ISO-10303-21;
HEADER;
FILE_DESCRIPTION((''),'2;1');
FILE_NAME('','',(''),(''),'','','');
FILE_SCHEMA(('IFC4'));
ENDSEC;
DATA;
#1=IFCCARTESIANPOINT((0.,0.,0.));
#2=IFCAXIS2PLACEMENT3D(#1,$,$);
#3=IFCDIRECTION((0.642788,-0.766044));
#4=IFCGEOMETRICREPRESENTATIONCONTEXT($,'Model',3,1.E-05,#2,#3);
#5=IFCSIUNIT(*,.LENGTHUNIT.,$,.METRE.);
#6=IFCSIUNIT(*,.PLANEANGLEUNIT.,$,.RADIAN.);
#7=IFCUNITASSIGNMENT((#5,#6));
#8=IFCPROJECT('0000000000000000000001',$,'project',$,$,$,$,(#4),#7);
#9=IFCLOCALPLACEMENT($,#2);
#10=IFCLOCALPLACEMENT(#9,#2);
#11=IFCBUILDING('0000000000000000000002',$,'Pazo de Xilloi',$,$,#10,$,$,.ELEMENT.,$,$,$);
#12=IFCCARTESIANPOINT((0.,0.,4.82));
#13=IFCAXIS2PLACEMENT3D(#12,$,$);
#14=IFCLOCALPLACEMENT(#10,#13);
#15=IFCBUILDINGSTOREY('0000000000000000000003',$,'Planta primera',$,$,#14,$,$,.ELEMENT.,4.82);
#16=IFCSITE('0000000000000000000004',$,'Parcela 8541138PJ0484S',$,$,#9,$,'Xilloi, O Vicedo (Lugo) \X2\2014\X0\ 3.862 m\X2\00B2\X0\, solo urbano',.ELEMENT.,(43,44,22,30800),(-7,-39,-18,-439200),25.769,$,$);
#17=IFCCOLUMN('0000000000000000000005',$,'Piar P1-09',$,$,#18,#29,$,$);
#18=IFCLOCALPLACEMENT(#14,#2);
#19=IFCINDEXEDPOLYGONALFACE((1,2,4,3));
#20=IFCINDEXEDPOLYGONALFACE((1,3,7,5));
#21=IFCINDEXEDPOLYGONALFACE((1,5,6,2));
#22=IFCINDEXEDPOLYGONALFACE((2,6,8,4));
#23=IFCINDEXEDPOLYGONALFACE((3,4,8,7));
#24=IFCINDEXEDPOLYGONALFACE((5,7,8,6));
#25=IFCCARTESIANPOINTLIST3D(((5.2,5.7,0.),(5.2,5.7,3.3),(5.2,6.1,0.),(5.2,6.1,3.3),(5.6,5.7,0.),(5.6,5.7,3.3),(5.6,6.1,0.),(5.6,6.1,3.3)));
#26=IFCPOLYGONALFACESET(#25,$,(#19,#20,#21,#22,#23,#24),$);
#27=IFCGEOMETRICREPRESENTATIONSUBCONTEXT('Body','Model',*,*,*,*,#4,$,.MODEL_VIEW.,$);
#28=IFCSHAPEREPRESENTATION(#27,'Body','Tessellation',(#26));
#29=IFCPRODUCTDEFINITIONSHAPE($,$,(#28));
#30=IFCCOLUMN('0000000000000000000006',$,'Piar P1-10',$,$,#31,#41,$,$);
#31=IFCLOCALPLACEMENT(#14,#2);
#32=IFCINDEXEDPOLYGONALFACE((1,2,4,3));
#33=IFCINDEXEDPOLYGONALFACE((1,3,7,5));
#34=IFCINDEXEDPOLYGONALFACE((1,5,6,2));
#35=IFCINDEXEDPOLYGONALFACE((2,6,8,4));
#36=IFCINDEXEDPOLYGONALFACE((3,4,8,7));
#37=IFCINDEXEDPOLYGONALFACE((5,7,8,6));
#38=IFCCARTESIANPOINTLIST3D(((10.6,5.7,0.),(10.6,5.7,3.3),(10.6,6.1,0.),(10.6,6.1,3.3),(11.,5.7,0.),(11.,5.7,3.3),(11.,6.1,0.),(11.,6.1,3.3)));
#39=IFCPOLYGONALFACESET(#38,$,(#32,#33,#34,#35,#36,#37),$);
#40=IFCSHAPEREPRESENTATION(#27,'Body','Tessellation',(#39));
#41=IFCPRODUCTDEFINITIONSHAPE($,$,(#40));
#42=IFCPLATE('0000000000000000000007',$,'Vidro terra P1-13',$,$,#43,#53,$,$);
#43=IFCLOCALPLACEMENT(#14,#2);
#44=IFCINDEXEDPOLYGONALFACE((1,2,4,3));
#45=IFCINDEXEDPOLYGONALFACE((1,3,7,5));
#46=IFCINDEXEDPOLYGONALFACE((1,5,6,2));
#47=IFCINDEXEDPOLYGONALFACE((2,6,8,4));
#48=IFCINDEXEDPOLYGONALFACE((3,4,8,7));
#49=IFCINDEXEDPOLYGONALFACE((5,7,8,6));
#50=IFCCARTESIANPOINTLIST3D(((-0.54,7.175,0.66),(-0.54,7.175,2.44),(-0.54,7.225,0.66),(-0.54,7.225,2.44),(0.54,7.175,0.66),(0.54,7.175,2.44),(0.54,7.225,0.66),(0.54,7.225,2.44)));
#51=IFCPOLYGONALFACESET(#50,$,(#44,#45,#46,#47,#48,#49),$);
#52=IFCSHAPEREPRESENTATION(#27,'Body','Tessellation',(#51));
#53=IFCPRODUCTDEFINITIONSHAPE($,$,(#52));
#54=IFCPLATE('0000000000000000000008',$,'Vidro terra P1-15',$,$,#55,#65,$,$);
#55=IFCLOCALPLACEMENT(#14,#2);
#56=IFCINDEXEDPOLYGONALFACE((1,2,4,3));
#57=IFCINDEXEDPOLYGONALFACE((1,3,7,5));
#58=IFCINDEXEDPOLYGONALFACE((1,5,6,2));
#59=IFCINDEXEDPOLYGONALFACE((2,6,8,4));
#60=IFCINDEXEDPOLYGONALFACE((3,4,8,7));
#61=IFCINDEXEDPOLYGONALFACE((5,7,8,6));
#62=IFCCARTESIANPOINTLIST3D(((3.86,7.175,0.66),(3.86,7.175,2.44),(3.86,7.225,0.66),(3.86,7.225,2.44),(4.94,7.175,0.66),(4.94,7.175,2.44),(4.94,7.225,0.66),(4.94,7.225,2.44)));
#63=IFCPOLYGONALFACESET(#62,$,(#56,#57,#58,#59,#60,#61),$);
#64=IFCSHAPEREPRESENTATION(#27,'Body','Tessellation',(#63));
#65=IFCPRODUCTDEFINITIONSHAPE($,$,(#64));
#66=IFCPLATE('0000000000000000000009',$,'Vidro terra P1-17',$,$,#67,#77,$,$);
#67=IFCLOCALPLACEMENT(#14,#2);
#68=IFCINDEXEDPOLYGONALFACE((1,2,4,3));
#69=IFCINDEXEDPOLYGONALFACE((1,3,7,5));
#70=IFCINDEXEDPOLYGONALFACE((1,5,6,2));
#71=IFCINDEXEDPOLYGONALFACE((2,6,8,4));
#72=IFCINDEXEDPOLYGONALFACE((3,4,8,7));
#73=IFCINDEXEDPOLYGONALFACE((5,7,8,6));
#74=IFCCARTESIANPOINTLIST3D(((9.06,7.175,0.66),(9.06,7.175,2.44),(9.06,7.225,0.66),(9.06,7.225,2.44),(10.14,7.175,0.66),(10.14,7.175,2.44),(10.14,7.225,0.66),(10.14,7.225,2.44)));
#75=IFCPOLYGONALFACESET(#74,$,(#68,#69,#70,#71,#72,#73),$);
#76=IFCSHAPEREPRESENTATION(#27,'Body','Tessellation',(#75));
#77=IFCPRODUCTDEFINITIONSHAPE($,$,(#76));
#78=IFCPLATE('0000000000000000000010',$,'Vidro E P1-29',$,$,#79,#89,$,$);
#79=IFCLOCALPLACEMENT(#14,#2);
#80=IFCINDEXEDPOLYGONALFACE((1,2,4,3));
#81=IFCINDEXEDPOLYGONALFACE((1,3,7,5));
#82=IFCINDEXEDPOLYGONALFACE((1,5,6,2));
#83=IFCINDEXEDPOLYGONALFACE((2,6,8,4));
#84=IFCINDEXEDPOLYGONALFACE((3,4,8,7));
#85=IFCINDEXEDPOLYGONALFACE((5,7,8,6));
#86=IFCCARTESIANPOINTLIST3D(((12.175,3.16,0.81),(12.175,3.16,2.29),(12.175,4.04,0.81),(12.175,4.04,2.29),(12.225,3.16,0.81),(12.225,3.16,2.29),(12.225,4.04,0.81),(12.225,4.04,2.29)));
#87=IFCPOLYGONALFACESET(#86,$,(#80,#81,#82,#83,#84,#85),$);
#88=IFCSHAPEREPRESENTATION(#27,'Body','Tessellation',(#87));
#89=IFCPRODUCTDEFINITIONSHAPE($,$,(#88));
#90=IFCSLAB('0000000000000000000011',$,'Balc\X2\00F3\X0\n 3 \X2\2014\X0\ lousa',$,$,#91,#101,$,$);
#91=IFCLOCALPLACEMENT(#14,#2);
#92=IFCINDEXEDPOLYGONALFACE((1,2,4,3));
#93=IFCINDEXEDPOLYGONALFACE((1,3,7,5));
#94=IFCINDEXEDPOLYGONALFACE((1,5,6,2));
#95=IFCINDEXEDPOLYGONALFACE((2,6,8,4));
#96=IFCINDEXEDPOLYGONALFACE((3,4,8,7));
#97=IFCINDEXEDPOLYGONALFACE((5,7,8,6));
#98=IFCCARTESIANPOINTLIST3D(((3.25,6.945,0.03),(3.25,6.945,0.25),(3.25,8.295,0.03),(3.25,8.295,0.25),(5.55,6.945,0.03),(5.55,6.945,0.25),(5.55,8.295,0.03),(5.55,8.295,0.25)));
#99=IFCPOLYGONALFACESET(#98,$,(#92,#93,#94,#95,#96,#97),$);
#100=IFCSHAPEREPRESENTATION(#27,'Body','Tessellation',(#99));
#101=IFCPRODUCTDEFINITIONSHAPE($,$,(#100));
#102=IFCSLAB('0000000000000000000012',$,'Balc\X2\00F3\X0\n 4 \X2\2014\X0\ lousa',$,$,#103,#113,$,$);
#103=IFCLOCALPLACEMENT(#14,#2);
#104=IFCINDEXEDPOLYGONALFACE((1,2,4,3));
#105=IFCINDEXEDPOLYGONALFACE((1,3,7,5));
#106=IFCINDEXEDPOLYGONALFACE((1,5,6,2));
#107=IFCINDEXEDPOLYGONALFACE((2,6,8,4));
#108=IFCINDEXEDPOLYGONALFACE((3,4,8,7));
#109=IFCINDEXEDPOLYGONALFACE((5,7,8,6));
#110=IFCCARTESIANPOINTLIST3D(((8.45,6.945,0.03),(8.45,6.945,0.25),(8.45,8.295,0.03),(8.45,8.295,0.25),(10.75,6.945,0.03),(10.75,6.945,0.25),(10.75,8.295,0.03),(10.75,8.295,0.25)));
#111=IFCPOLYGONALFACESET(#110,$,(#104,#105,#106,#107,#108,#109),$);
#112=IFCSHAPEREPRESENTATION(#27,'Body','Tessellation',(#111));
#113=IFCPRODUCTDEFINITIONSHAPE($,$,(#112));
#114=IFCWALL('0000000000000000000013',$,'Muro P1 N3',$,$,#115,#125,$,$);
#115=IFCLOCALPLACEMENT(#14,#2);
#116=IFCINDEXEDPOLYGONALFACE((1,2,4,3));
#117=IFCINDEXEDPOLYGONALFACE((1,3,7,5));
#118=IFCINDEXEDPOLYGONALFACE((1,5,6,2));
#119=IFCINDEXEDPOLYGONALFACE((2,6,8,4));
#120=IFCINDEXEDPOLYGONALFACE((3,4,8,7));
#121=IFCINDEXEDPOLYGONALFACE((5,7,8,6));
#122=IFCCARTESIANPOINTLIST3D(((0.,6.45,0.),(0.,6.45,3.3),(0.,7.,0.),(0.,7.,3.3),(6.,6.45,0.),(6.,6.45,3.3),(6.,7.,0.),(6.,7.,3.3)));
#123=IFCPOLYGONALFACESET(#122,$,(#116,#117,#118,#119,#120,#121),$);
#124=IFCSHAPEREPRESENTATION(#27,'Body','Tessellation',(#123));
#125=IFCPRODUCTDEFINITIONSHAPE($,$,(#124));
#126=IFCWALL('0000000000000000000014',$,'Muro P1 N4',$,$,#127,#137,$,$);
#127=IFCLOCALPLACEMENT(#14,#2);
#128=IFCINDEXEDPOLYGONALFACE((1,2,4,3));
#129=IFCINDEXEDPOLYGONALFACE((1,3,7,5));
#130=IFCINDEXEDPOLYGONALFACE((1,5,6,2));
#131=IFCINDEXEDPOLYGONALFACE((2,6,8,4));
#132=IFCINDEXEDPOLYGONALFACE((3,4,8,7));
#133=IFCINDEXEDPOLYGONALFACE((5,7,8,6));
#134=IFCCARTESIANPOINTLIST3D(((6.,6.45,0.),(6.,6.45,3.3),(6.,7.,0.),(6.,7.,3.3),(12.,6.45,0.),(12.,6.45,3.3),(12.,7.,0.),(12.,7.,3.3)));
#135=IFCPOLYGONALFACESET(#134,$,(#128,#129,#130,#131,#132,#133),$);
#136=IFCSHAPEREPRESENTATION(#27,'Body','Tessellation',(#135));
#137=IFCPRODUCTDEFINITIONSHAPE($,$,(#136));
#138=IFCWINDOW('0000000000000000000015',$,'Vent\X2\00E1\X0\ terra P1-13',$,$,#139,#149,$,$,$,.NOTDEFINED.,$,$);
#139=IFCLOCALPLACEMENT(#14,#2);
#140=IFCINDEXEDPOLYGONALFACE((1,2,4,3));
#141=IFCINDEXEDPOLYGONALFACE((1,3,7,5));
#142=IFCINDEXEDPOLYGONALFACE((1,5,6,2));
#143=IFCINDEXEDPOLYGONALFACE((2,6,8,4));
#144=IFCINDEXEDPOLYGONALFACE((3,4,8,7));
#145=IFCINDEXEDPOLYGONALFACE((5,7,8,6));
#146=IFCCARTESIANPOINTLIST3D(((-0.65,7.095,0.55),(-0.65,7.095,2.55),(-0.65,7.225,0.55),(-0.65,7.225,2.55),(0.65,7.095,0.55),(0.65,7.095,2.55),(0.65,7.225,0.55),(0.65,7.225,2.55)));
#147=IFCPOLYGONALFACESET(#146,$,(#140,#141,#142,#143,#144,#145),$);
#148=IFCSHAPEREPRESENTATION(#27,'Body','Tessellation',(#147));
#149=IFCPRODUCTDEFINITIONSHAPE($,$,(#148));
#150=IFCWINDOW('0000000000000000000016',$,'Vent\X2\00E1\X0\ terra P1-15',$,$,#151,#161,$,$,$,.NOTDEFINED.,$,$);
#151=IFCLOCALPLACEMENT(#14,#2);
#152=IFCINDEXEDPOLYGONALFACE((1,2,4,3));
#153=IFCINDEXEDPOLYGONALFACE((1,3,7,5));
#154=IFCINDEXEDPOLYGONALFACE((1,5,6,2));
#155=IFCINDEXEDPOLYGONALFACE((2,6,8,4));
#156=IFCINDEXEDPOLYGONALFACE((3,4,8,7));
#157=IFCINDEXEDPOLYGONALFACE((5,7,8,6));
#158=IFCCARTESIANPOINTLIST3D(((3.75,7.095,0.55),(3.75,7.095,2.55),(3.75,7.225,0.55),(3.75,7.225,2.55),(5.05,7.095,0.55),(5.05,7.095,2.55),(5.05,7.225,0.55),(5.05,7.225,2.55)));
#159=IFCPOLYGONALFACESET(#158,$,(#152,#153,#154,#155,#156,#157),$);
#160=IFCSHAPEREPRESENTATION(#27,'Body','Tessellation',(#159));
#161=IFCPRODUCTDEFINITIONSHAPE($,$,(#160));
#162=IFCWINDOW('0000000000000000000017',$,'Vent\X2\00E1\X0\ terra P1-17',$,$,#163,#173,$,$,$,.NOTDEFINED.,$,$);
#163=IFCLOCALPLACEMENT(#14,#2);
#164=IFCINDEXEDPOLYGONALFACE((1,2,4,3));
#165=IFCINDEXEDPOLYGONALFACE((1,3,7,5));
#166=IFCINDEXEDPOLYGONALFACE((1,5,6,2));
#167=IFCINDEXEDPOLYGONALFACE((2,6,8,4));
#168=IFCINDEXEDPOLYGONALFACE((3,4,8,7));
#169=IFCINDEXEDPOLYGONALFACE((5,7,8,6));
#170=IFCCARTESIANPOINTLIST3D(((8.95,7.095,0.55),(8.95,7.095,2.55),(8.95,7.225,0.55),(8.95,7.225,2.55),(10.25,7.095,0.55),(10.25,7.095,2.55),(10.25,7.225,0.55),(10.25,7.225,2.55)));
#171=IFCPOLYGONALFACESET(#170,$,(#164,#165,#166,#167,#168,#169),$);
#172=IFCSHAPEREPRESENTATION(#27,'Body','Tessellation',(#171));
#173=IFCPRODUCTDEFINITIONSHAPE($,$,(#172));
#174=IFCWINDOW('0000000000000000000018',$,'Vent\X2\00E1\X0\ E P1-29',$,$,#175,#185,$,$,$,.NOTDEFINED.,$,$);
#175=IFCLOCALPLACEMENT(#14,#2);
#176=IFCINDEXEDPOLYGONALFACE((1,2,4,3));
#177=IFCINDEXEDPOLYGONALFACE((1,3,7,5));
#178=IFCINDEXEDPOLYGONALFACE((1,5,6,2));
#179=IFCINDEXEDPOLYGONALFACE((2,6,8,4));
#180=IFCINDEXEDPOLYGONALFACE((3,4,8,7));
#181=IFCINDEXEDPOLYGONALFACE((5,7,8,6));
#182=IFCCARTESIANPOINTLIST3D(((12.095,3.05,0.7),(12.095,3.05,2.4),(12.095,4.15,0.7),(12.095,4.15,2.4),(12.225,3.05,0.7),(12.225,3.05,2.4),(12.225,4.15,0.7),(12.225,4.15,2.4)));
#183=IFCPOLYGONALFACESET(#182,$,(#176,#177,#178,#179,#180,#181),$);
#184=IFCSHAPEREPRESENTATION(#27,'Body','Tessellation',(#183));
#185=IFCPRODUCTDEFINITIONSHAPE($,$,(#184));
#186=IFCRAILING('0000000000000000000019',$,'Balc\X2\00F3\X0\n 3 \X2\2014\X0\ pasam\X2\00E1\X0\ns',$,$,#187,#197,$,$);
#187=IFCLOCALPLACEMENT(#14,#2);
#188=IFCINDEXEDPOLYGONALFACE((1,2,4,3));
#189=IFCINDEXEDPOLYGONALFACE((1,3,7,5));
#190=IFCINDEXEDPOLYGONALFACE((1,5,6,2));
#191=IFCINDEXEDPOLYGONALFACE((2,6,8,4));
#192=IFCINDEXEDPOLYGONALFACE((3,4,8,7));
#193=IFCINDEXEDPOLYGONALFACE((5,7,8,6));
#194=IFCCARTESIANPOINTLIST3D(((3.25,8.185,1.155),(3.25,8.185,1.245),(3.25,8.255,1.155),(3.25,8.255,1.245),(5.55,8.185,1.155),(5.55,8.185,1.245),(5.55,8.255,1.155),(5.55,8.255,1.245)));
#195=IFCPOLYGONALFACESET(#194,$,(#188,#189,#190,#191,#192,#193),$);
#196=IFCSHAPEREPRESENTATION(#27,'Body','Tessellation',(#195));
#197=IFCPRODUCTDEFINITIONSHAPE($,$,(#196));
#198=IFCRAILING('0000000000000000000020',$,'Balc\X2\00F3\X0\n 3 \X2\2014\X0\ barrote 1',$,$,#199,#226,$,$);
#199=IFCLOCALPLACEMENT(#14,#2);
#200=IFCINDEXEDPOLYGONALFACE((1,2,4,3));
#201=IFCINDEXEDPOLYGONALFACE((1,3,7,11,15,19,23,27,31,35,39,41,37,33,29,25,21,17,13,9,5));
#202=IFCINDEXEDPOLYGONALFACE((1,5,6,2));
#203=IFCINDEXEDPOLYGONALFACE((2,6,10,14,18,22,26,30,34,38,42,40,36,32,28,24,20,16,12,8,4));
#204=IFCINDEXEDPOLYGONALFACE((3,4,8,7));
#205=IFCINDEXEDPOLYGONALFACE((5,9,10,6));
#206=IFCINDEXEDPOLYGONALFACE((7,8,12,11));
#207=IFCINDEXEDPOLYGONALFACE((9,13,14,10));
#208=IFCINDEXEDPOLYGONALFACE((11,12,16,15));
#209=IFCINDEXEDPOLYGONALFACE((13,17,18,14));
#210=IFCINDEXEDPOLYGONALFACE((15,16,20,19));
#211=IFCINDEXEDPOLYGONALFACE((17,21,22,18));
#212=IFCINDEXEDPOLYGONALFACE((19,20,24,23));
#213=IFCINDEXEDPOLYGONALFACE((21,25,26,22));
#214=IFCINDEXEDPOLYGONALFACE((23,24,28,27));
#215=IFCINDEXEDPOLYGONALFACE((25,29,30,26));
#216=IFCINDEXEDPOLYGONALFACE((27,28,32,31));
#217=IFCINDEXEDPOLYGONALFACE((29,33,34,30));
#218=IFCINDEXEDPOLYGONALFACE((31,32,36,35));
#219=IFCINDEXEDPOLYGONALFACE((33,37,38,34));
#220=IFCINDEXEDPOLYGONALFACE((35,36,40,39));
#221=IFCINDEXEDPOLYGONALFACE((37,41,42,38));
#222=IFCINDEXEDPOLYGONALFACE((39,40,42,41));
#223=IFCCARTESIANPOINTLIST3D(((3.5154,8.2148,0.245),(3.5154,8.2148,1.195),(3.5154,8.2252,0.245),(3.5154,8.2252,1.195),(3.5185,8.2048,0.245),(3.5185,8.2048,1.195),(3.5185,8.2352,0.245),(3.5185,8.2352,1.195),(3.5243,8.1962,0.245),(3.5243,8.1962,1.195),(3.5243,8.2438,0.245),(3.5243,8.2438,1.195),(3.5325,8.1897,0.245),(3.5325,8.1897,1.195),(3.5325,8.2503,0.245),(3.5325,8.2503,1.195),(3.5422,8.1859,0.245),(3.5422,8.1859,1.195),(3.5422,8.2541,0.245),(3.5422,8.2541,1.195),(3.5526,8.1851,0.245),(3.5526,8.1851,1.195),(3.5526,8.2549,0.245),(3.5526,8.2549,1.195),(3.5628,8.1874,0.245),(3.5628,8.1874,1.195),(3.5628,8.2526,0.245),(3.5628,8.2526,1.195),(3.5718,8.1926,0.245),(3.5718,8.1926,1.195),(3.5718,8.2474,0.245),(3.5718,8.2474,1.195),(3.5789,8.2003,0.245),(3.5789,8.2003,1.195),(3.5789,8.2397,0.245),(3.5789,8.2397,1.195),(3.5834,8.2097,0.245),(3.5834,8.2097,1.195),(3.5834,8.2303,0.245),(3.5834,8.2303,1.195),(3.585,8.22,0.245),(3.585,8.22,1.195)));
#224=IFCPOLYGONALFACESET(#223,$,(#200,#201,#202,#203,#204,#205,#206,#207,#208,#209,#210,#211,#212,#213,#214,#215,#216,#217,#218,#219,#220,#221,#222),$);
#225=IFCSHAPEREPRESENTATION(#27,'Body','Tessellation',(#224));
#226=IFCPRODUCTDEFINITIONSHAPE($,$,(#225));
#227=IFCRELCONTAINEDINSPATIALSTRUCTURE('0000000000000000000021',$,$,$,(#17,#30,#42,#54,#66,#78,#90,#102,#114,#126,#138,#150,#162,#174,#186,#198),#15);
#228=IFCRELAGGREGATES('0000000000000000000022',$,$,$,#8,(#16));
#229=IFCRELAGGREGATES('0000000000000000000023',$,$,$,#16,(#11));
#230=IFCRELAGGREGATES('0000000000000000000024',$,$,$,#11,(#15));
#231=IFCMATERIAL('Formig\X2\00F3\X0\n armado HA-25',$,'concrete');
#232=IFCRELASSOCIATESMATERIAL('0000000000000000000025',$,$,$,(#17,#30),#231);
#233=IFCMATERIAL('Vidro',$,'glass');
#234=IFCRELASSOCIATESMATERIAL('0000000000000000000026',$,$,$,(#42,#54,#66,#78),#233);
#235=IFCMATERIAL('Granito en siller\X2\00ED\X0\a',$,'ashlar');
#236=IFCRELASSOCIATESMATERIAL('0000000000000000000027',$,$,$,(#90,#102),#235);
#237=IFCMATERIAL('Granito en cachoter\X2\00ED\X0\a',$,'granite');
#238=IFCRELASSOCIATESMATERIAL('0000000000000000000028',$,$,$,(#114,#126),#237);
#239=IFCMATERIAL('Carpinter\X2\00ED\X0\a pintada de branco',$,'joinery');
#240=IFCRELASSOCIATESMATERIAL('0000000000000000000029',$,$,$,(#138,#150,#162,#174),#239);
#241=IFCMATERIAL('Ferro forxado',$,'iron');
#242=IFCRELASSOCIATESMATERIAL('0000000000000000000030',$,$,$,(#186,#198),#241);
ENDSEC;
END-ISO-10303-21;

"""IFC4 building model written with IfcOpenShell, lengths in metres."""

from ifc_helpers import new_model, si_unit, direction, frame, origin, origin_2d, place, context, subcontext, project, spatial, rectangle, circle, extrude, material, element, save


model = new_model("IFC4")

# Units and contexts
model_context = context("Model", 3, precision=1e-05, world=origin(), true_north=direction((0.642788, -0.766044)))
body_context = subcontext(model_context, "Body", "Model", "MODEL_VIEW")
ifc_project = project(units=[si_unit("LENGTHUNIT", "METRE"), si_unit("PLANEANGLEUNIT", "RADIAN")], contexts=[model_context])

# Site, building, storey
site_placement = place(None, origin())
site = spatial("IfcSite", under=ifc_project, at=site_placement, Name="Parcela 8541138PJ0484S", LongName="Xilloi, O Vicedo (Lugo) — 3.862 m², solo urbano", CompositionType="ELEMENT", RefLatitude=(43, 44, 22, 30800), RefLongitude=(-7, -39, -18, -439200), RefElevation=25.769)
building_placement = place(site_placement, origin())
building = spatial("IfcBuilding", under=site, at=building_placement, Name="Pazo de Xilloi", CompositionType="ELEMENT")
storey_placement = place(building_placement, frame((0.0, 0.0, 4.82)))
storey = spatial("IfcBuildingStorey", under=building, at=storey_placement, Name="Planta primera", CompositionType="ELEMENT", Elevation=4.82)

# Columns
ifc_material_1 = material(Name="Formigón armado HA-25", Category="concrete")
for number, where, name in (
    (1, (5.4, 5.9, 1.65), "Piar P1-09"),
    (2, (10.8, 5.9, 1.65), "Piar P1-10"),
):
    element("IfcColumn", number, at=place(storey_placement, frame(where)), inside=storey, material=ifc_material_1, Name=name, context=body_context, shape_type="SweptSolid", body=[
        extrude(rectangle(XDim=0.4, YDim=0.4, at=origin_2d()), frame((0.0, 0.0, -1.65)), (0.0, 0.0, 1.0), 3.3),
    ])

# Plates
ifc_material_2 = material(Name="Vidro", Category="glass")
for number, where, name in (
    (3, (0.0, 7.2, 1.55), "Vidro terra P1-13"),
    (4, (4.4, 7.2, 1.55), "Vidro terra P1-15"),
    (5, (9.6, 7.2, 1.55), "Vidro terra P1-17"),
):
    element("IfcPlate", number, at=place(storey_placement, frame(where)), inside=storey, material=ifc_material_2, Name=name, context=body_context, shape_type="SweptSolid", body=[
        extrude(rectangle(XDim=1.08, YDim=0.05, at=origin_2d()), frame((0.0, 0.0, -0.89)), (0.0, 0.0, 1.0), 1.78),
    ])
plate_placement = place(storey_placement, frame((12.2, 3.6, 1.55)))
element("IfcPlate", 6, at=plate_placement, inside=storey, material=ifc_material_2, Name="Vidro E P1-29", context=body_context, shape_type="SweptSolid", body=[
    extrude(rectangle(XDim=0.05, YDim=0.88, at=origin_2d()), frame((0.0, 0.0, -0.74)), (0.0, 0.0, 1.0), 1.48),
])

# Slabs
ifc_material_3 = material(Name="Granito en sillería", Category="ashlar")
for number, where, name in (
    (7, (4.4, 7.62, 0.14), "Balcón 3 — lousa"),
    (8, (9.6, 7.62, 0.14), "Balcón 4 — lousa"),
):
    element("IfcSlab", number, at=place(storey_placement, frame(where)), inside=storey, material=ifc_material_3, Name=name, context=body_context, shape_type="SweptSolid", body=[
        extrude(rectangle(XDim=2.3, YDim=1.35, at=origin_2d()), frame((0.0, 0.0, -0.11)), (0.0, 0.0, 1.0), 0.22),
    ])

# Walls
ifc_material_4 = material(Name="Granito en cachotería", Category="granite")
for number, where, name in (
    (9, (3.0, 6.725, 1.65), "Muro P1 N3"),
    (10, (9.0, 6.725, 1.65), "Muro P1 N4"),
):
    element("IfcWall", number, at=place(storey_placement, frame(where)), inside=storey, material=ifc_material_4, Name=name, context=body_context, shape_type="SweptSolid", body=[
        extrude(rectangle(XDim=6.0, YDim=0.55, at=origin_2d()), frame((0.0, 0.0, -1.65)), (0.0, 0.0, 1.0), 3.3),
    ])

# Windows
ifc_material_5 = material(Name="Carpintería pintada de branco", Category="joinery")
for number, where, name in (
    (11, (0.0, 7.16, 1.55), "Ventá terra P1-13"),
    (12, (4.4, 7.16, 1.55), "Ventá terra P1-15"),
    (13, (9.6, 7.16, 1.55), "Ventá terra P1-17"),
):
    element("IfcWindow", number, at=place(storey_placement, frame(where)), inside=storey, material=ifc_material_5, Name=name, PredefinedType="NOTDEFINED", context=body_context, shape_type="SweptSolid", body=[
        extrude(rectangle(XDim=1.3, YDim=0.13, at=origin_2d()), frame((0.0, 0.0, -1.0)), (0.0, 0.0, 1.0), 2.0),
    ])
window_placement = place(storey_placement, frame((12.16, 3.6, 1.55)))
element("IfcWindow", 14, at=window_placement, inside=storey, material=ifc_material_5, Name="Ventá E P1-29", PredefinedType="NOTDEFINED", context=body_context, shape_type="SweptSolid", body=[
    extrude(rectangle(XDim=0.13, YDim=1.1, at=origin_2d()), frame((0.0, 0.0, -0.85)), (0.0, 0.0, 1.0), 1.7),
])

# Railings
ifc_material_6 = material(Name="Ferro forxado", Category="iron")
railing_1_placement = place(storey_placement, frame((4.4, 8.22, 1.2)))
element("IfcRailing", 15, at=railing_1_placement, inside=storey, material=ifc_material_6, Name="Balcón 3 — pasamáns", context=body_context, shape_type="SweptSolid", body=[
    extrude(rectangle(XDim=2.3, YDim=0.07, at=origin_2d()), frame((0.0, 0.0, -0.045)), (0.0, 0.0, 1.0), 0.09),
])
for number, where, name in (
    (16, (3.55, 8.22, 0.72), "Balcón 3 — barrote 1"),
):
    element("IfcRailing", number, at=place(storey_placement, frame(where)), inside=storey, material=ifc_material_6, Name=name, context=body_context, shape_type="SweptSolid", body=[
        extrude(circle(Radius=0.035, at=origin_2d()), frame((0.0, 0.0, -0.475)), (0.0, 0.0, 1.0), 0.95),
    ])

save(model, "model.ifc")
